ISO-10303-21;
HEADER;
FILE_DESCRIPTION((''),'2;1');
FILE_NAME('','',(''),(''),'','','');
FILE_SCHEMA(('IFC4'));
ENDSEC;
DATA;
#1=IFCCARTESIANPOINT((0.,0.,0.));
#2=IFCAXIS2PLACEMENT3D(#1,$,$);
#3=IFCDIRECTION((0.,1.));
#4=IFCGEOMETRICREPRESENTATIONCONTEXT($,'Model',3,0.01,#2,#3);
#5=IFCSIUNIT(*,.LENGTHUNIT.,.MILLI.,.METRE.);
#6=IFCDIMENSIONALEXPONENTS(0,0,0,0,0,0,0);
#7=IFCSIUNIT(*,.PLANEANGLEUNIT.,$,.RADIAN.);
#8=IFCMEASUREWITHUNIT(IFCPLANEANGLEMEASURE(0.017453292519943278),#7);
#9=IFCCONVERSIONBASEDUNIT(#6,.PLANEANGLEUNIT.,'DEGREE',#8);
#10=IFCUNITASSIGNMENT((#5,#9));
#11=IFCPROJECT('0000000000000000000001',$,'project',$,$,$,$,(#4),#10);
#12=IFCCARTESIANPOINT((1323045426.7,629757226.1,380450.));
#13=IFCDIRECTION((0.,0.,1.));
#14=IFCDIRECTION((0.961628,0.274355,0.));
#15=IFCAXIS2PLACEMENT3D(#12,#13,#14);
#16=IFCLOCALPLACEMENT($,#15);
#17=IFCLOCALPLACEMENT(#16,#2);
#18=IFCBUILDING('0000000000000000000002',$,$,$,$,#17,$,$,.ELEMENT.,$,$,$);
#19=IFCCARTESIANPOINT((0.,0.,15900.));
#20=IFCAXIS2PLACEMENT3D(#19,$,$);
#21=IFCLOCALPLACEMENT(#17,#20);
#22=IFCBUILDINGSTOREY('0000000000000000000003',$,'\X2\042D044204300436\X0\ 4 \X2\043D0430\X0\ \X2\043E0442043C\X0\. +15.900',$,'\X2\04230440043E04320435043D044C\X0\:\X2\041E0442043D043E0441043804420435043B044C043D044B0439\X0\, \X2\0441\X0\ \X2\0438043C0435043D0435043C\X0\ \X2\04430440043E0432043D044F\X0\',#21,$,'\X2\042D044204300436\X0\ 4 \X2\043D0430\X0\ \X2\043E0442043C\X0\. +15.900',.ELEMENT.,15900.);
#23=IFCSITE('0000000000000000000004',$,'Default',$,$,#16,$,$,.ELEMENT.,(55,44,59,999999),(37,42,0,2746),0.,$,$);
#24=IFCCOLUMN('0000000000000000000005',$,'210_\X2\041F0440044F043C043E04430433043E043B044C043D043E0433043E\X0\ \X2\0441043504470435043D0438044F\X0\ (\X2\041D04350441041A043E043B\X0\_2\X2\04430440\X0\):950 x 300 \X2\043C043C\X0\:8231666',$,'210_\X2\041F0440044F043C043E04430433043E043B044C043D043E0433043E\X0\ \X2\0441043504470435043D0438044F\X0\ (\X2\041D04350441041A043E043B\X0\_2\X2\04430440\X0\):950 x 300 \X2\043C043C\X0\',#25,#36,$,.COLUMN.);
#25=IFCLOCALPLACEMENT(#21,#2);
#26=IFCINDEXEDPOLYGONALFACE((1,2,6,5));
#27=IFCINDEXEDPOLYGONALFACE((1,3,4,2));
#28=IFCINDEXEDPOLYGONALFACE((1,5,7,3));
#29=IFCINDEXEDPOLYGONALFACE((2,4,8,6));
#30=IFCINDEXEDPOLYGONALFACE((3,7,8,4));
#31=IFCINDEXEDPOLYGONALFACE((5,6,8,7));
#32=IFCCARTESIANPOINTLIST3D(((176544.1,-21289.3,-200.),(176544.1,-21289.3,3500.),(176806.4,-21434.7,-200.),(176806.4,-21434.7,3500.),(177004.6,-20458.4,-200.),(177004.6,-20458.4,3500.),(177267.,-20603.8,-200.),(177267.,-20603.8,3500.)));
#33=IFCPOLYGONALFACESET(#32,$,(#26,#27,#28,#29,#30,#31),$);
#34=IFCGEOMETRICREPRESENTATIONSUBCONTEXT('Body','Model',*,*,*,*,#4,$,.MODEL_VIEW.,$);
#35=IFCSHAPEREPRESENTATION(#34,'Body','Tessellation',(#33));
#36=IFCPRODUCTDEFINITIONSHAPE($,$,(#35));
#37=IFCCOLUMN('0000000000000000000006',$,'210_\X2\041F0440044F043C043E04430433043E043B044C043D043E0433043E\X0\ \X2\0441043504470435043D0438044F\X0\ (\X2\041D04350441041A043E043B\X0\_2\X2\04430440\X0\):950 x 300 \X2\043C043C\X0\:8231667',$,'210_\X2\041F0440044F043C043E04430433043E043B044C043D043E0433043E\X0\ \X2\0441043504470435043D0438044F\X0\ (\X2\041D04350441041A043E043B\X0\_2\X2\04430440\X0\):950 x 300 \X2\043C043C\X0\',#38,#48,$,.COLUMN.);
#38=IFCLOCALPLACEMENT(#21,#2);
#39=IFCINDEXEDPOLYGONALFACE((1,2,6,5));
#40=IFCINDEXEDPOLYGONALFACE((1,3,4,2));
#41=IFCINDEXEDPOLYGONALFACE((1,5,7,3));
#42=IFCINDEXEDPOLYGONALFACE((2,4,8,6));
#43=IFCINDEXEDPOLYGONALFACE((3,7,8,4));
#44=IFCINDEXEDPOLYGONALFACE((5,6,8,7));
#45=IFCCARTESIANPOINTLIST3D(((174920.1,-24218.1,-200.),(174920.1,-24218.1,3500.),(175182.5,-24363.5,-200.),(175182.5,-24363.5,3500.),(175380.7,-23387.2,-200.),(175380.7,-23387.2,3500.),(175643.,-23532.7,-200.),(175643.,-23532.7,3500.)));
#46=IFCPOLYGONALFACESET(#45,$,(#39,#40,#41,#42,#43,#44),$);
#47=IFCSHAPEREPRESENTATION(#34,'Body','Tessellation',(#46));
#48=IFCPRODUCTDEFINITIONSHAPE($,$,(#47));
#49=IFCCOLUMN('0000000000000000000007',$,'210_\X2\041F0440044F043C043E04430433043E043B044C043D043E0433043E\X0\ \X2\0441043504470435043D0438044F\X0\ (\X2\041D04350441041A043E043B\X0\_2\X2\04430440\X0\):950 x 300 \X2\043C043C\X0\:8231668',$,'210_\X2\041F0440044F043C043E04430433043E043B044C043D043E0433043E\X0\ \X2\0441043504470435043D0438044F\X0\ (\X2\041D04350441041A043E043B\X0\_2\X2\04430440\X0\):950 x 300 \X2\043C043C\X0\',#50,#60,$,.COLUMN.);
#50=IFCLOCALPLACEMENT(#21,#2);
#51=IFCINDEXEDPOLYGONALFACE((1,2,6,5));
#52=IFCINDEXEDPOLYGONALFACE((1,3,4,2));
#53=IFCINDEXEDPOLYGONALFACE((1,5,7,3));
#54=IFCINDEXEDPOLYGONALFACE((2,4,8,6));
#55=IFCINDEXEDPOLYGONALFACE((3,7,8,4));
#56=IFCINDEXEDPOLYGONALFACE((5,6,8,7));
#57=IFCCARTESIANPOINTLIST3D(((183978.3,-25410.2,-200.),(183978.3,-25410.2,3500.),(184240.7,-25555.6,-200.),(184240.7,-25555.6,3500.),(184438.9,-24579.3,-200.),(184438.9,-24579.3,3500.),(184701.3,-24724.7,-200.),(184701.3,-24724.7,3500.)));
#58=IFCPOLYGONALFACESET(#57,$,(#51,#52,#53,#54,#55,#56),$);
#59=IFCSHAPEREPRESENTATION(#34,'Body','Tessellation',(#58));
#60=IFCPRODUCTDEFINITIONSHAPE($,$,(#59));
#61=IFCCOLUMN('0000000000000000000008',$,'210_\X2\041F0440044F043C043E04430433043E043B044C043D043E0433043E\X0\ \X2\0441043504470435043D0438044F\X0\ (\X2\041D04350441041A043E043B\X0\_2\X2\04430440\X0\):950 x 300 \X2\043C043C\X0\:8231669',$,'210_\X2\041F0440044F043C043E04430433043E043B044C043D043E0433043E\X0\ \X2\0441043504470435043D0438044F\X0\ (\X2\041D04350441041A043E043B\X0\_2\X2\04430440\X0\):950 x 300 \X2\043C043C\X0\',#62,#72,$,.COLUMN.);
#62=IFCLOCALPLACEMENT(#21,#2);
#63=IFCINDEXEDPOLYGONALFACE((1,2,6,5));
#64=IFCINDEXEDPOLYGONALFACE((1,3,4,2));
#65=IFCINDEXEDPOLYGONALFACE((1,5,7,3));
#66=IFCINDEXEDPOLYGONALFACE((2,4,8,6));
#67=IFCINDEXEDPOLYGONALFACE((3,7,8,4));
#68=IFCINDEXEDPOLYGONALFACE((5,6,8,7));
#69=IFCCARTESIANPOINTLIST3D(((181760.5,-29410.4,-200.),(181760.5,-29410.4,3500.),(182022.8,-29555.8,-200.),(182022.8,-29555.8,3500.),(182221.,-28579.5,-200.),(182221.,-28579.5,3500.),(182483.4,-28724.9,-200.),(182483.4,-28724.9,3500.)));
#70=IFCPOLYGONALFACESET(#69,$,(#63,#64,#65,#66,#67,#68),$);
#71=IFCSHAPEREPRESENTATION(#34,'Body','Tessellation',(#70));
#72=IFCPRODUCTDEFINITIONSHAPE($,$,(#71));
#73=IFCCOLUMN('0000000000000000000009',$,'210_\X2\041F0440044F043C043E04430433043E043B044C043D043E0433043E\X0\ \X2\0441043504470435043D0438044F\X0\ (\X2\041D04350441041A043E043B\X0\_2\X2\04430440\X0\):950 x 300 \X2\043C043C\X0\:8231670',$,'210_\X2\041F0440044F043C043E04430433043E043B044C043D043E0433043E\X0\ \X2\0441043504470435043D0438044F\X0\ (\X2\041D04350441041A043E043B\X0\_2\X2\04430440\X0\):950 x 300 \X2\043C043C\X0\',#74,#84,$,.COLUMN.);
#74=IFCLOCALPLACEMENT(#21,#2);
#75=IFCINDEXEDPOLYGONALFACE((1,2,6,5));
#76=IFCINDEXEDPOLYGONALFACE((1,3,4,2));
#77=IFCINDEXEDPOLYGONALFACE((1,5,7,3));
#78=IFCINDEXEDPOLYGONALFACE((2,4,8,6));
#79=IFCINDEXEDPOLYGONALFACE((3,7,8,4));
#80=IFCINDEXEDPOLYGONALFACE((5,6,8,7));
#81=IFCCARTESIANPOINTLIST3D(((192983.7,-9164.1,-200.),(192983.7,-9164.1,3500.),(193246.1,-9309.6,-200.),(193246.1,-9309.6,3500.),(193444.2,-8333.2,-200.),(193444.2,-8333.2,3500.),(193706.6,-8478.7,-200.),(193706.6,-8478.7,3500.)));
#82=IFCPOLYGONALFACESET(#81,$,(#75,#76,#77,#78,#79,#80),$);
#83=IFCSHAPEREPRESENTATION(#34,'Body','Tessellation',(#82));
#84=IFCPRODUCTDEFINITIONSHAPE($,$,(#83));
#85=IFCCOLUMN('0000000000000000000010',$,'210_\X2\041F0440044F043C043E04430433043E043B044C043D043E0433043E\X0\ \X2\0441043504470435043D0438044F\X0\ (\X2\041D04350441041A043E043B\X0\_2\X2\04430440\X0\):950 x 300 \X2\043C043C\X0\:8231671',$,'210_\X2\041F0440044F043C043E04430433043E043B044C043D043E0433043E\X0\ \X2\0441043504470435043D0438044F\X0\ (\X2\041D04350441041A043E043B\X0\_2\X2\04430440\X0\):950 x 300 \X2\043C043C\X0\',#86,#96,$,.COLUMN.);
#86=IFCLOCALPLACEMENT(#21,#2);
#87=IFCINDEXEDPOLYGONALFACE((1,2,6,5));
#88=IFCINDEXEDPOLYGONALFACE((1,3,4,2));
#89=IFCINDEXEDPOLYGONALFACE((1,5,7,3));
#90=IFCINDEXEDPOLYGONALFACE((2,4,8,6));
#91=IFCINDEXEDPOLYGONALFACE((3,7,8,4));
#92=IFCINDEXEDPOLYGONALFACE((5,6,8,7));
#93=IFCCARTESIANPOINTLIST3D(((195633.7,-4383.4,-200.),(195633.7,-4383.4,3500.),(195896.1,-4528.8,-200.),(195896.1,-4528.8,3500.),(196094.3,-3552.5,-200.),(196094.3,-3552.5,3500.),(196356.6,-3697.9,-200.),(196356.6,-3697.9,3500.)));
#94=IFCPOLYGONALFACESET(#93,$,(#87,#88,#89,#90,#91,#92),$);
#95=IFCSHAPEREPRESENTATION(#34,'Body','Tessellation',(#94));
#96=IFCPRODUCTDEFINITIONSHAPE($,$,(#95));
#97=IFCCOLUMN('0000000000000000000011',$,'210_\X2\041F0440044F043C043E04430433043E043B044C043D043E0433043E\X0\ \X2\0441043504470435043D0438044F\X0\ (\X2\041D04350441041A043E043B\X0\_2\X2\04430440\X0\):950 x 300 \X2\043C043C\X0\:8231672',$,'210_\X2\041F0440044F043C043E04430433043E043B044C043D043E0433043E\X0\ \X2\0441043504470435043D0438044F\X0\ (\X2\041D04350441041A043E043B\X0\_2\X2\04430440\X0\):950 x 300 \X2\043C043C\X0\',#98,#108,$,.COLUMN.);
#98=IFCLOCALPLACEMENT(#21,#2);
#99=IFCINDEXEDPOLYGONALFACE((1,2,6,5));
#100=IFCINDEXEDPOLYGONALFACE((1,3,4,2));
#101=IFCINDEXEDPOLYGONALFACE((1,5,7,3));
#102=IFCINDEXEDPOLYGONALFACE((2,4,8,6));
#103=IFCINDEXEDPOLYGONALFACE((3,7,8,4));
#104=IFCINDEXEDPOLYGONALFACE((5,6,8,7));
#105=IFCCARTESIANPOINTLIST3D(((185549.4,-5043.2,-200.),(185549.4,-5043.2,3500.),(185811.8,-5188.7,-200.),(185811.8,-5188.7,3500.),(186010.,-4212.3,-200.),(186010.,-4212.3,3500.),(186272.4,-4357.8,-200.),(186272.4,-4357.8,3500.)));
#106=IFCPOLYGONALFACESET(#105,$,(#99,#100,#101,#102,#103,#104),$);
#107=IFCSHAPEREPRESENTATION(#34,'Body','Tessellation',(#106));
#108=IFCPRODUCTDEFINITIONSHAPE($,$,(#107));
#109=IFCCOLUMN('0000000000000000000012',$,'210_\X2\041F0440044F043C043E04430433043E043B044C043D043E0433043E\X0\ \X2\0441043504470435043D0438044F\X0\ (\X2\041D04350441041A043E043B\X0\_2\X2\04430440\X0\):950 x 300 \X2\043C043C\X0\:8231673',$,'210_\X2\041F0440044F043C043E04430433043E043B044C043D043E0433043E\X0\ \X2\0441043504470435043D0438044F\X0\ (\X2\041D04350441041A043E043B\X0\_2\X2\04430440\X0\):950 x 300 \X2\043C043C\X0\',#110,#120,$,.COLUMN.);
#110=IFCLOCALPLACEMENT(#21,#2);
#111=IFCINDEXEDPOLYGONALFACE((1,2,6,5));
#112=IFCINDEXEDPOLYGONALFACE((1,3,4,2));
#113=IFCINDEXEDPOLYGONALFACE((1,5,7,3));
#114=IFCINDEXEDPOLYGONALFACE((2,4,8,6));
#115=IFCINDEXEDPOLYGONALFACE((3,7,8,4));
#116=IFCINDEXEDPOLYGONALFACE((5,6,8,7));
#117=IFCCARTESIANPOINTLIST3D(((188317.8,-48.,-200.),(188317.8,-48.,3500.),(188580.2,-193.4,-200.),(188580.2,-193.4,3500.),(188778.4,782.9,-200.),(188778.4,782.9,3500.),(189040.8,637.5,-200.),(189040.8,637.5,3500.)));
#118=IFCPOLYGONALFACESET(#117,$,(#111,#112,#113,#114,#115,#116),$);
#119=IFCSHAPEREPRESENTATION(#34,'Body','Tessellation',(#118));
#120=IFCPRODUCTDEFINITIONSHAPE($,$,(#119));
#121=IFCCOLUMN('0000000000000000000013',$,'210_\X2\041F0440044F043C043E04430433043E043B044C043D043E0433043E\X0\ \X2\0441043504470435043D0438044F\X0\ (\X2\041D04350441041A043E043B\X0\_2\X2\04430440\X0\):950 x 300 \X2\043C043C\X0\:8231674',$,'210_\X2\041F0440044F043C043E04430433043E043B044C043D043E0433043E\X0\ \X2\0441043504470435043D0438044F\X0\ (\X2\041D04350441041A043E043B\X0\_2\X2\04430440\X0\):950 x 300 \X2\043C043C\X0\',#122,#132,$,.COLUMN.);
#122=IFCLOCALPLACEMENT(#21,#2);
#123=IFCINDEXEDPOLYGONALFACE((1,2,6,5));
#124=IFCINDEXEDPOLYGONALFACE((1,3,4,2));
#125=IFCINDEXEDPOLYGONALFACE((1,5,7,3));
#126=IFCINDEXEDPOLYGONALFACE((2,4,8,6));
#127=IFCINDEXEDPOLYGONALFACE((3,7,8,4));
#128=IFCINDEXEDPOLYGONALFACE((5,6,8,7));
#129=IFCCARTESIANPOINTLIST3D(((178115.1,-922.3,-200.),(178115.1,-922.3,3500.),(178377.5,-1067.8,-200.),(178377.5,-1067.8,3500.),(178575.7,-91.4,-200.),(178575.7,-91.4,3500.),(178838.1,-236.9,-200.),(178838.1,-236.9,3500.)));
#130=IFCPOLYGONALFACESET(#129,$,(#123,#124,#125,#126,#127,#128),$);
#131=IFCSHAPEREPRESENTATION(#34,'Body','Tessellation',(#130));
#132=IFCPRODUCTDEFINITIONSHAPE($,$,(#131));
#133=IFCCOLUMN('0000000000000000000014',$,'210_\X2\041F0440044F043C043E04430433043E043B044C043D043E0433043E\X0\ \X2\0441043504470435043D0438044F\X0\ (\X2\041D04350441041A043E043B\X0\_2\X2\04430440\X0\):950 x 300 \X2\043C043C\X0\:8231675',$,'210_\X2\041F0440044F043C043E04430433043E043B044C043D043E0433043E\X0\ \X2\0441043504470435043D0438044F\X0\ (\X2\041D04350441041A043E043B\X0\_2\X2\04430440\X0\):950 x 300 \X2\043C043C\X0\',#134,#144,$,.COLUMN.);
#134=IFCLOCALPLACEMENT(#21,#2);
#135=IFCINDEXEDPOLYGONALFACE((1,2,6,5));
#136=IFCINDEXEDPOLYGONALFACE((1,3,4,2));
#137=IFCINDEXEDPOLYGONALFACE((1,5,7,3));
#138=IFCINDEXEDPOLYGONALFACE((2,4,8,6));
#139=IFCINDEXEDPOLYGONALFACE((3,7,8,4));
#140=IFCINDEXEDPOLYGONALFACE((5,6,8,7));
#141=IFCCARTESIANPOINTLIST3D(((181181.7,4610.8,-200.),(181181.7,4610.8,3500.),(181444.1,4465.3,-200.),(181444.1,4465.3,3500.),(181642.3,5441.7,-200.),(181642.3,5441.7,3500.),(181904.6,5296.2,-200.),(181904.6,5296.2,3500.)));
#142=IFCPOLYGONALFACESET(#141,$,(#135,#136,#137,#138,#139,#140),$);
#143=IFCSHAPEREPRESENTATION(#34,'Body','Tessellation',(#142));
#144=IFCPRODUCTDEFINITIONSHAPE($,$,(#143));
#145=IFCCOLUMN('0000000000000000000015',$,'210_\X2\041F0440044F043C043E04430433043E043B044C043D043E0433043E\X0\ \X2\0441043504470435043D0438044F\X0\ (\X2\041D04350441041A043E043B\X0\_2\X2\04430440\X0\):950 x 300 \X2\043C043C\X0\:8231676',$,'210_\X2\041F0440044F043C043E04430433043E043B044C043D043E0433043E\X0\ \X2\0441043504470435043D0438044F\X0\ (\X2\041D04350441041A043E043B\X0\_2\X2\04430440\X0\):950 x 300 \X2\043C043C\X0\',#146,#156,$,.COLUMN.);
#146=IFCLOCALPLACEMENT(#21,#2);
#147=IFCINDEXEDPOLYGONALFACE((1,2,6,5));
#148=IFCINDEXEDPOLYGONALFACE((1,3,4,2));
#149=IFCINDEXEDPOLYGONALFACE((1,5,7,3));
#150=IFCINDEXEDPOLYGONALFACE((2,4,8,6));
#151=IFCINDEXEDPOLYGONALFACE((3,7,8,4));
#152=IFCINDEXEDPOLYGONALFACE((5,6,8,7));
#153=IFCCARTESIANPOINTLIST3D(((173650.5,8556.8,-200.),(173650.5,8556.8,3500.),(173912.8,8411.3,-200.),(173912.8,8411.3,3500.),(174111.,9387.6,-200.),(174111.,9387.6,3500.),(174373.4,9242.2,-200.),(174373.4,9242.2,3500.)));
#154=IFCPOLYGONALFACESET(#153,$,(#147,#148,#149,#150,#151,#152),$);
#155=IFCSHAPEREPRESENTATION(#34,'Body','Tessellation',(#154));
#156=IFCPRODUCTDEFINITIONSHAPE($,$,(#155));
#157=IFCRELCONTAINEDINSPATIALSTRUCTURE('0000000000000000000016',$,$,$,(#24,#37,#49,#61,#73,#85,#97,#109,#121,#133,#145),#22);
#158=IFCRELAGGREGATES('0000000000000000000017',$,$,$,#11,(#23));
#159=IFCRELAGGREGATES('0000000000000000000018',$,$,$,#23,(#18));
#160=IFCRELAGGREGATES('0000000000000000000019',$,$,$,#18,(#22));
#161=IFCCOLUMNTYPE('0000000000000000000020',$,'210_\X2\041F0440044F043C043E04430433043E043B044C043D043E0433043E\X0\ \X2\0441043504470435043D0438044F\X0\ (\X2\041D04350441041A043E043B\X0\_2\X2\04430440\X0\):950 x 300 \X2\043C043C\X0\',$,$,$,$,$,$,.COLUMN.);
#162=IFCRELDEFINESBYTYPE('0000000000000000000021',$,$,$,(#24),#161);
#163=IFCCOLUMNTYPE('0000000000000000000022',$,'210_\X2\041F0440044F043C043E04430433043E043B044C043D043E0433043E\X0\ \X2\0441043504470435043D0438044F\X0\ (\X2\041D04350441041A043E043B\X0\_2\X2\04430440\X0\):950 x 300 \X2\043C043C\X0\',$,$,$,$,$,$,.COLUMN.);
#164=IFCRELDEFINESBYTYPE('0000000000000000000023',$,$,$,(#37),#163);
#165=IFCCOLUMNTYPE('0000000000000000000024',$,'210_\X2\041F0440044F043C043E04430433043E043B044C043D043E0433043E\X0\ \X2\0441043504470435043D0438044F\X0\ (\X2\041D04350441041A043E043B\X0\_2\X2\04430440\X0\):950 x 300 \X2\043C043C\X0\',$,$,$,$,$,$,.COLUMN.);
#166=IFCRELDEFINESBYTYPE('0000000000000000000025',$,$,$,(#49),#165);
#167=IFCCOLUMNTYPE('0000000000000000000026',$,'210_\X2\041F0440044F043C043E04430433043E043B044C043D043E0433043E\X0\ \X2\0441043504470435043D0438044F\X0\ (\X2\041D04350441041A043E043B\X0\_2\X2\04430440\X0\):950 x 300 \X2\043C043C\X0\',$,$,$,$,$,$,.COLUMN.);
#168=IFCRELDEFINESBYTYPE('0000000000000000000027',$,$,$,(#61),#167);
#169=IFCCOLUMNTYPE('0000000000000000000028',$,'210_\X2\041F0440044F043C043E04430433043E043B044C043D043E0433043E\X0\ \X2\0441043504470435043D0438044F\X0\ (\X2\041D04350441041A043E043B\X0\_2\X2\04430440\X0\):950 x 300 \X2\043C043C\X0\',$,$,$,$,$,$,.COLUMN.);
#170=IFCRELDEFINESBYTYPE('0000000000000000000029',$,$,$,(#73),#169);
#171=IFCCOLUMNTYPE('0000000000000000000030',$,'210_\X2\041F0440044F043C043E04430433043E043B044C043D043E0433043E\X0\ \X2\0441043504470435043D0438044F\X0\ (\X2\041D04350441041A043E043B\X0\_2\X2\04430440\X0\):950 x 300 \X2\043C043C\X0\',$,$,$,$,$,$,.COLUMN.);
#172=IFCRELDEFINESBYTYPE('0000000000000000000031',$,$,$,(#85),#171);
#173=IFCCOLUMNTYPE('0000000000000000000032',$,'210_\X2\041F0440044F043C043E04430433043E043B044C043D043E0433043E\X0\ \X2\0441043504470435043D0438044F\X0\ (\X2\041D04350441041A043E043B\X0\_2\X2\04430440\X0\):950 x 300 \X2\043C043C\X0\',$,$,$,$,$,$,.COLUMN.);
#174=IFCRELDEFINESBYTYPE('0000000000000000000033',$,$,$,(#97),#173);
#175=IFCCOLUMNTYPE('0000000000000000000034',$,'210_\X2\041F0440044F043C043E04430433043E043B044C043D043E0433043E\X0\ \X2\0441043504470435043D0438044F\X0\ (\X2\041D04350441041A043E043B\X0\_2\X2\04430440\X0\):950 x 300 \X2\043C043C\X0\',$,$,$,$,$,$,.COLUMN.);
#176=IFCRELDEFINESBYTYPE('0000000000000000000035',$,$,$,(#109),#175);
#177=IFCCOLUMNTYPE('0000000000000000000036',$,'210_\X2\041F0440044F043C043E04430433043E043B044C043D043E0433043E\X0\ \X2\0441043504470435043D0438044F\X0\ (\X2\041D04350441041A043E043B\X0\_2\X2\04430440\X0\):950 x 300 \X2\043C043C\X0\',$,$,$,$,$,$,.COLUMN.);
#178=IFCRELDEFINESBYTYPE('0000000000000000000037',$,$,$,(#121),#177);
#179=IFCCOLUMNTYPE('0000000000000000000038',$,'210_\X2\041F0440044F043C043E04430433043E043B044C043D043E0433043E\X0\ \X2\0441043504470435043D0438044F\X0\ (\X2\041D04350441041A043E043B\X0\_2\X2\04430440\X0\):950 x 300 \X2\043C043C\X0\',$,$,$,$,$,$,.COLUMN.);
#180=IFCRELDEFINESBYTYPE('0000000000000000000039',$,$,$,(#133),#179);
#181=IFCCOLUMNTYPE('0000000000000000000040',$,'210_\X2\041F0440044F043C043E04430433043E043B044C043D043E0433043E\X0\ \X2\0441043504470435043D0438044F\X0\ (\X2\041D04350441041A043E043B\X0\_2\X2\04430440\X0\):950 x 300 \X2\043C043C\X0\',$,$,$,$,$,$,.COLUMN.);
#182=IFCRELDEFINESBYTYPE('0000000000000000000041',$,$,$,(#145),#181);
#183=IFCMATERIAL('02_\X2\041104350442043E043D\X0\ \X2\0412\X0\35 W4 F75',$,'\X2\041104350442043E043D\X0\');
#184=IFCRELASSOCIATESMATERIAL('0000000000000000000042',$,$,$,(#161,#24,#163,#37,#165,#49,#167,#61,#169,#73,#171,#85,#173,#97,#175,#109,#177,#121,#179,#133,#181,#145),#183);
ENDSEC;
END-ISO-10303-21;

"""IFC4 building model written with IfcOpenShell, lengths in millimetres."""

from ifc_helpers import new_model, entity, si_unit, converted_unit, direction, frame, origin, place, context, subcontext, project, spatial, indexed_curve, outline, extrude, source, transform, mapped, material, type_object, type_shapes, element, save


model = new_model("IFC4")

# Units and contexts
model_context = context("Model", 3, precision=0.01, world=origin(), true_north=direction((0.0, 1.0)))
body_context = subcontext(model_context, "Body", "Model", "MODEL_VIEW")
ifc_project = project(units=[si_unit("LENGTHUNIT", "METRE", prefix="MILLI"), converted_unit("PLANEANGLEUNIT", "DEGREE", entity("IfcPlaneAngleMeasure", 0.017453292519943278), si_unit("PLANEANGLEUNIT", "RADIAN"), dimensions=[0, 0, 0, 0, 0, 0, 0])], contexts=[model_context])

# Site, building, storey
site_placement = place(None, frame((1323045426.7, 629757226.1, 380450.0), z_axis=(0.0, 0.0, 1.0), x_axis=(0.961628, 0.274355, 0.0)))
site = spatial("IfcSite", under=ifc_project, at=site_placement, Name="Default", CompositionType="ELEMENT", RefLatitude=(55, 44, 59, 999999), RefLongitude=(37, 42, 0, 2746), RefElevation=0.0)
building_placement = place(site_placement, origin())
building = spatial("IfcBuilding", under=site, at=building_placement, CompositionType="ELEMENT")
storey_placement = place(building_placement, frame((0.0, 0.0, 15900.0)))
storey = spatial("IfcBuildingStorey", under=building, at=storey_placement, Name="Этаж 4 на отм. +15.900", ObjectType="Уровень:Относительный, с именем уровня", LongName="Этаж 4 на отм. +15.900", CompositionType="ELEMENT", Elevation=15900.0)

# Columns
ifc_material_1 = material(Name="02_Бетон В35 W4 F75", Category="Бетон")
column_type_1 = type_object("IfcColumnType", Name="210_Прямоугольного сечения (НесКол_2ур):950 x 300 мм", PredefinedType="COLUMN", material=ifc_material_1)
shared_shape_1 = source(origin(), body_context, "Body", "SweptSolid", [
    extrude(outline(indexed_curve([(-150.0, -475.0), (150.0, -475.0), (150.0, 475.0), (-150.0, 475.0), (-150.0, -475.0)], self_intersect=False)), frame((176905.5, -20946.6, 15700.0), z_axis=(0.0, 0.0, 1.0), x_axis=(-0.87462, 0.48481, 0.0)), (0.0, 0.0, 1.0), 3700.0),
])
type_shapes(column_type_1, [shared_shape_1])
column_1_placement = place(storey_placement, frame((0.0, 0.0, -15900.0)))
element("IfcColumn", 1, at=column_1_placement, inside=storey, type_object=column_type_1, material=ifc_material_1, Name="210_Прямоугольного сечения (НесКол_2ур):950 x 300 мм:8231666", ObjectType="210_Прямоугольного сечения (НесКол_2ур):950 x 300 мм", PredefinedType="COLUMN", context=body_context, shape_type="MappedRepresentation", body=[
    mapped(shared_shape_1, transform((0.0, 0.0, 0.0), scale=1.0)),
])
column_type_2 = type_object("IfcColumnType", Name="210_Прямоугольного сечения (НесКол_2ур):950 x 300 мм", PredefinedType="COLUMN", material=ifc_material_1)
shared_shape_2 = source(origin(), body_context, "Body", "SweptSolid", [
    extrude(outline(indexed_curve([(-150.0, -475.0), (150.0, -475.0), (150.0, 475.0), (-150.0, 475.0), (-150.0, -475.0)], self_intersect=False)), frame((175281.6, -23875.4, 15700.0), z_axis=(0.0, 0.0, 1.0), x_axis=(-0.87462, 0.48481, 0.0)), (0.0, 0.0, 1.0), 3700.0),
])
type_shapes(column_type_2, [shared_shape_2])
column_2_placement = place(storey_placement, frame((0.0, 0.0, -15900.0)))
element("IfcColumn", 2, at=column_2_placement, inside=storey, type_object=column_type_2, material=ifc_material_1, Name="210_Прямоугольного сечения (НесКол_2ур):950 x 300 мм:8231667", ObjectType="210_Прямоугольного сечения (НесКол_2ур):950 x 300 мм", PredefinedType="COLUMN", context=body_context, shape_type="MappedRepresentation", body=[
    mapped(shared_shape_2, transform((0.0, 0.0, 0.0), scale=1.0)),
])
column_type_3 = type_object("IfcColumnType", Name="210_Прямоугольного сечения (НесКол_2ур):950 x 300 мм", PredefinedType="COLUMN", material=ifc_material_1)
shared_shape_3 = source(origin(), body_context, "Body", "SweptSolid", [
    extrude(outline(indexed_curve([(-150.0, -475.0), (150.0, -475.0), (150.0, 475.0), (-150.0, 475.0), (-150.0, -475.0)], self_intersect=False)), frame((184339.8, -25067.5, 15700.0), z_axis=(0.0, 0.0, 1.0), x_axis=(-0.87462, 0.48481, 0.0)), (0.0, 0.0, 1.0), 3700.0),
])
type_shapes(column_type_3, [shared_shape_3])
column_3_placement = place(storey_placement, frame((0.0, 0.0, -15900.0)))
element("IfcColumn", 3, at=column_3_placement, inside=storey, type_object=column_type_3, material=ifc_material_1, Name="210_Прямоугольного сечения (НесКол_2ур):950 x 300 мм:8231668", ObjectType="210_Прямоугольного сечения (НесКол_2ур):950 x 300 мм", PredefinedType="COLUMN", context=body_context, shape_type="MappedRepresentation", body=[
    mapped(shared_shape_3, transform((0.0, 0.0, 0.0), scale=1.0)),
])
column_type_4 = type_object("IfcColumnType", Name="210_Прямоугольного сечения (НесКол_2ур):950 x 300 мм", PredefinedType="COLUMN", material=ifc_material_1)
shared_shape_4 = source(origin(), body_context, "Body", "SweptSolid", [
    extrude(outline(indexed_curve([(-150.0, -475.0), (150.0, -475.0), (150.0, 475.0), (-150.0, 475.0), (-150.0, -475.0)], self_intersect=False)), frame((182121.9, -29067.7, 15700.0), z_axis=(0.0, 0.0, 1.0), x_axis=(-0.87462, 0.48481, 0.0)), (0.0, 0.0, 1.0), 3700.0),
])
type_shapes(column_type_4, [shared_shape_4])
column_4_placement = place(storey_placement, frame((0.0, 0.0, -15900.0)))
element("IfcColumn", 4, at=column_4_placement, inside=storey, type_object=column_type_4, material=ifc_material_1, Name="210_Прямоугольного сечения (НесКол_2ур):950 x 300 мм:8231669", ObjectType="210_Прямоугольного сечения (НесКол_2ур):950 x 300 мм", PredefinedType="COLUMN", context=body_context, shape_type="MappedRepresentation", body=[
    mapped(shared_shape_4, transform((0.0, 0.0, 0.0), scale=1.0)),
])
column_type_5 = type_object("IfcColumnType", Name="210_Прямоугольного сечения (НесКол_2ур):950 x 300 мм", PredefinedType="COLUMN", material=ifc_material_1)
shared_shape_5 = source(origin(), body_context, "Body", "SweptSolid", [
    extrude(outline(indexed_curve([(-150.0, -475.0), (150.0, -475.0), (150.0, 475.0), (-150.0, 475.0), (-150.0, -475.0)], self_intersect=False)), frame((193345.2, -8821.4, 15700.0), z_axis=(0.0, 0.0, 1.0), x_axis=(-0.87462, 0.48481, 0.0)), (0.0, 0.0, 1.0), 3700.0),
])
type_shapes(column_type_5, [shared_shape_5])
column_5_placement = place(storey_placement, frame((0.0, 0.0, -15900.0)))
element("IfcColumn", 5, at=column_5_placement, inside=storey, type_object=column_type_5, material=ifc_material_1, Name="210_Прямоугольного сечения (НесКол_2ур):950 x 300 мм:8231670", ObjectType="210_Прямоугольного сечения (НесКол_2ур):950 x 300 мм", PredefinedType="COLUMN", context=body_context, shape_type="MappedRepresentation", body=[
    mapped(shared_shape_5, transform((0.0, 0.0, 0.0), scale=1.0)),
])
column_type_6 = type_object("IfcColumnType", Name="210_Прямоугольного сечения (НесКол_2ур):950 x 300 мм", PredefinedType="COLUMN", material=ifc_material_1)
shared_shape_6 = source(origin(), body_context, "Body", "SweptSolid", [
    extrude(outline(indexed_curve([(-150.0, -475.0), (150.0, -475.0), (150.0, 475.0), (-150.0, 475.0), (-150.0, -475.0)], self_intersect=False)), frame((195995.2, -4040.7, 15700.0), z_axis=(0.0, 0.0, 1.0), x_axis=(-0.87462, 0.48481, 0.0)), (0.0, 0.0, 1.0), 3700.0),
])
type_shapes(column_type_6, [shared_shape_6])
column_6_placement = place(storey_placement, frame((0.0, 0.0, -15900.0)))
element("IfcColumn", 6, at=column_6_placement, inside=storey, type_object=column_type_6, material=ifc_material_1, Name="210_Прямоугольного сечения (НесКол_2ур):950 x 300 мм:8231671", ObjectType="210_Прямоугольного сечения (НесКол_2ур):950 x 300 мм", PredefinedType="COLUMN", context=body_context, shape_type="MappedRepresentation", body=[
    mapped(shared_shape_6, transform((0.0, 0.0, 0.0), scale=1.0)),
])
column_type_7 = type_object("IfcColumnType", Name="210_Прямоугольного сечения (НесКол_2ур):950 x 300 мм", PredefinedType="COLUMN", material=ifc_material_1)
shared_shape_7 = source(origin(), body_context, "Body", "SweptSolid", [
    extrude(outline(indexed_curve([(-150.0, -475.0), (150.0, -475.0), (150.0, 475.0), (-150.0, 475.0), (-150.0, -475.0)], self_intersect=False)), frame((185910.9, -4700.5, 15700.0), z_axis=(0.0, 0.0, 1.0), x_axis=(-0.87462, 0.48481, 0.0)), (0.0, 0.0, 1.0), 3700.0),
])
type_shapes(column_type_7, [shared_shape_7])
column_7_placement = place(storey_placement, frame((0.0, 0.0, -15900.0)))
element("IfcColumn", 7, at=column_7_placement, inside=storey, type_object=column_type_7, material=ifc_material_1, Name="210_Прямоугольного сечения (НесКол_2ур):950 x 300 мм:8231672", ObjectType="210_Прямоугольного сечения (НесКол_2ур):950 x 300 мм", PredefinedType="COLUMN", context=body_context, shape_type="MappedRepresentation", body=[
    mapped(shared_shape_7, transform((0.0, 0.0, 0.0), scale=1.0)),
])
column_type_8 = type_object("IfcColumnType", Name="210_Прямоугольного сечения (НесКол_2ур):950 x 300 мм", PredefinedType="COLUMN", material=ifc_material_1)
shared_shape_8 = source(origin(), body_context, "Body", "SweptSolid", [
    extrude(outline(indexed_curve([(-150.0, -475.0), (150.0, -475.0), (150.0, 475.0), (-150.0, 475.0), (-150.0, -475.0)], self_intersect=False)), frame((188679.3, 294.7, 15700.0), z_axis=(0.0, 0.0, 1.0), x_axis=(-0.87462, 0.48481, 0.0)), (0.0, 0.0, 1.0), 3700.0),
])
type_shapes(column_type_8, [shared_shape_8])
column_8_placement = place(storey_placement, frame((0.0, 0.0, -15900.0)))
element("IfcColumn", 8, at=column_8_placement, inside=storey, type_object=column_type_8, material=ifc_material_1, Name="210_Прямоугольного сечения (НесКол_2ур):950 x 300 мм:8231673", ObjectType="210_Прямоугольного сечения (НесКол_2ур):950 x 300 мм", PredefinedType="COLUMN", context=body_context, shape_type="MappedRepresentation", body=[
    mapped(shared_shape_8, transform((0.0, 0.0, 0.0), scale=1.0)),
])
column_type_9 = type_object("IfcColumnType", Name="210_Прямоугольного сечения (НесКол_2ур):950 x 300 мм", PredefinedType="COLUMN", material=ifc_material_1)
shared_shape_9 = source(origin(), body_context, "Body", "SweptSolid", [
    extrude(outline(indexed_curve([(-150.0, -475.0), (150.0, -475.0), (150.0, 475.0), (-150.0, 475.0), (-150.0, -475.0)], self_intersect=False)), frame((178476.6, -579.6, 15700.0), z_axis=(0.0, 0.0, 1.0), x_axis=(-0.87462, 0.48481, 0.0)), (0.0, 0.0, 1.0), 3700.0),
])
type_shapes(column_type_9, [shared_shape_9])
column_9_placement = place(storey_placement, frame((0.0, 0.0, -15900.0)))
element("IfcColumn", 9, at=column_9_placement, inside=storey, type_object=column_type_9, material=ifc_material_1, Name="210_Прямоугольного сечения (НесКол_2ур):950 x 300 мм:8231674", ObjectType="210_Прямоугольного сечения (НесКол_2ур):950 x 300 мм", PredefinedType="COLUMN", context=body_context, shape_type="MappedRepresentation", body=[
    mapped(shared_shape_9, transform((0.0, 0.0, 0.0), scale=1.0)),
])
column_type_10 = type_object("IfcColumnType", Name="210_Прямоугольного сечения (НесКол_2ур):950 x 300 мм", PredefinedType="COLUMN", material=ifc_material_1)
shared_shape_10 = source(origin(), body_context, "Body", "SweptSolid", [
    extrude(outline(indexed_curve([(-150.0, -475.0), (150.0, -475.0), (150.0, 475.0), (-150.0, 475.0), (-150.0, -475.0)], self_intersect=False)), frame((181543.2, 4953.5, 15700.0), z_axis=(0.0, 0.0, 1.0), x_axis=(-0.87462, 0.48481, 0.0)), (0.0, 0.0, 1.0), 3700.0),
])
type_shapes(column_type_10, [shared_shape_10])
column_10_placement = place(storey_placement, frame((0.0, 0.0, -15900.0)))
element("IfcColumn", 10, at=column_10_placement, inside=storey, type_object=column_type_10, material=ifc_material_1, Name="210_Прямоугольного сечения (НесКол_2ур):950 x 300 мм:8231675", ObjectType="210_Прямоугольного сечения (НесКол_2ур):950 x 300 мм", PredefinedType="COLUMN", context=body_context, shape_type="MappedRepresentation", body=[
    mapped(shared_shape_10, transform((0.0, 0.0, 0.0), scale=1.0)),
])
column_type_11 = type_object("IfcColumnType", Name="210_Прямоугольного сечения (НесКол_2ур):950 x 300 мм", PredefinedType="COLUMN", material=ifc_material_1)
shared_shape_11 = source(origin(), body_context, "Body", "SweptSolid", [
    extrude(outline(indexed_curve([(-150.0, -475.0), (150.0, -475.0), (150.0, 475.0), (-150.0, 475.0), (-150.0, -475.0)], self_intersect=False)), frame((174011.9, 8899.5, 15700.0), z_axis=(0.0, 0.0, 1.0), x_axis=(-0.87462, 0.48481, 0.0)), (0.0, 0.0, 1.0), 3700.0),
])
type_shapes(column_type_11, [shared_shape_11])
column_11_placement = place(storey_placement, frame((0.0, 0.0, -15900.0)))
element("IfcColumn", 11, at=column_11_placement, inside=storey, type_object=column_type_11, material=ifc_material_1, Name="210_Прямоугольного сечения (НесКол_2ур):950 x 300 мм:8231676", ObjectType="210_Прямоугольного сечения (НесКол_2ур):950 x 300 мм", PredefinedType="COLUMN", context=body_context, shape_type="MappedRepresentation", body=[
    mapped(shared_shape_11, transform((0.0, 0.0, 0.0), scale=1.0)),
])

save(model, "model.ifc")
